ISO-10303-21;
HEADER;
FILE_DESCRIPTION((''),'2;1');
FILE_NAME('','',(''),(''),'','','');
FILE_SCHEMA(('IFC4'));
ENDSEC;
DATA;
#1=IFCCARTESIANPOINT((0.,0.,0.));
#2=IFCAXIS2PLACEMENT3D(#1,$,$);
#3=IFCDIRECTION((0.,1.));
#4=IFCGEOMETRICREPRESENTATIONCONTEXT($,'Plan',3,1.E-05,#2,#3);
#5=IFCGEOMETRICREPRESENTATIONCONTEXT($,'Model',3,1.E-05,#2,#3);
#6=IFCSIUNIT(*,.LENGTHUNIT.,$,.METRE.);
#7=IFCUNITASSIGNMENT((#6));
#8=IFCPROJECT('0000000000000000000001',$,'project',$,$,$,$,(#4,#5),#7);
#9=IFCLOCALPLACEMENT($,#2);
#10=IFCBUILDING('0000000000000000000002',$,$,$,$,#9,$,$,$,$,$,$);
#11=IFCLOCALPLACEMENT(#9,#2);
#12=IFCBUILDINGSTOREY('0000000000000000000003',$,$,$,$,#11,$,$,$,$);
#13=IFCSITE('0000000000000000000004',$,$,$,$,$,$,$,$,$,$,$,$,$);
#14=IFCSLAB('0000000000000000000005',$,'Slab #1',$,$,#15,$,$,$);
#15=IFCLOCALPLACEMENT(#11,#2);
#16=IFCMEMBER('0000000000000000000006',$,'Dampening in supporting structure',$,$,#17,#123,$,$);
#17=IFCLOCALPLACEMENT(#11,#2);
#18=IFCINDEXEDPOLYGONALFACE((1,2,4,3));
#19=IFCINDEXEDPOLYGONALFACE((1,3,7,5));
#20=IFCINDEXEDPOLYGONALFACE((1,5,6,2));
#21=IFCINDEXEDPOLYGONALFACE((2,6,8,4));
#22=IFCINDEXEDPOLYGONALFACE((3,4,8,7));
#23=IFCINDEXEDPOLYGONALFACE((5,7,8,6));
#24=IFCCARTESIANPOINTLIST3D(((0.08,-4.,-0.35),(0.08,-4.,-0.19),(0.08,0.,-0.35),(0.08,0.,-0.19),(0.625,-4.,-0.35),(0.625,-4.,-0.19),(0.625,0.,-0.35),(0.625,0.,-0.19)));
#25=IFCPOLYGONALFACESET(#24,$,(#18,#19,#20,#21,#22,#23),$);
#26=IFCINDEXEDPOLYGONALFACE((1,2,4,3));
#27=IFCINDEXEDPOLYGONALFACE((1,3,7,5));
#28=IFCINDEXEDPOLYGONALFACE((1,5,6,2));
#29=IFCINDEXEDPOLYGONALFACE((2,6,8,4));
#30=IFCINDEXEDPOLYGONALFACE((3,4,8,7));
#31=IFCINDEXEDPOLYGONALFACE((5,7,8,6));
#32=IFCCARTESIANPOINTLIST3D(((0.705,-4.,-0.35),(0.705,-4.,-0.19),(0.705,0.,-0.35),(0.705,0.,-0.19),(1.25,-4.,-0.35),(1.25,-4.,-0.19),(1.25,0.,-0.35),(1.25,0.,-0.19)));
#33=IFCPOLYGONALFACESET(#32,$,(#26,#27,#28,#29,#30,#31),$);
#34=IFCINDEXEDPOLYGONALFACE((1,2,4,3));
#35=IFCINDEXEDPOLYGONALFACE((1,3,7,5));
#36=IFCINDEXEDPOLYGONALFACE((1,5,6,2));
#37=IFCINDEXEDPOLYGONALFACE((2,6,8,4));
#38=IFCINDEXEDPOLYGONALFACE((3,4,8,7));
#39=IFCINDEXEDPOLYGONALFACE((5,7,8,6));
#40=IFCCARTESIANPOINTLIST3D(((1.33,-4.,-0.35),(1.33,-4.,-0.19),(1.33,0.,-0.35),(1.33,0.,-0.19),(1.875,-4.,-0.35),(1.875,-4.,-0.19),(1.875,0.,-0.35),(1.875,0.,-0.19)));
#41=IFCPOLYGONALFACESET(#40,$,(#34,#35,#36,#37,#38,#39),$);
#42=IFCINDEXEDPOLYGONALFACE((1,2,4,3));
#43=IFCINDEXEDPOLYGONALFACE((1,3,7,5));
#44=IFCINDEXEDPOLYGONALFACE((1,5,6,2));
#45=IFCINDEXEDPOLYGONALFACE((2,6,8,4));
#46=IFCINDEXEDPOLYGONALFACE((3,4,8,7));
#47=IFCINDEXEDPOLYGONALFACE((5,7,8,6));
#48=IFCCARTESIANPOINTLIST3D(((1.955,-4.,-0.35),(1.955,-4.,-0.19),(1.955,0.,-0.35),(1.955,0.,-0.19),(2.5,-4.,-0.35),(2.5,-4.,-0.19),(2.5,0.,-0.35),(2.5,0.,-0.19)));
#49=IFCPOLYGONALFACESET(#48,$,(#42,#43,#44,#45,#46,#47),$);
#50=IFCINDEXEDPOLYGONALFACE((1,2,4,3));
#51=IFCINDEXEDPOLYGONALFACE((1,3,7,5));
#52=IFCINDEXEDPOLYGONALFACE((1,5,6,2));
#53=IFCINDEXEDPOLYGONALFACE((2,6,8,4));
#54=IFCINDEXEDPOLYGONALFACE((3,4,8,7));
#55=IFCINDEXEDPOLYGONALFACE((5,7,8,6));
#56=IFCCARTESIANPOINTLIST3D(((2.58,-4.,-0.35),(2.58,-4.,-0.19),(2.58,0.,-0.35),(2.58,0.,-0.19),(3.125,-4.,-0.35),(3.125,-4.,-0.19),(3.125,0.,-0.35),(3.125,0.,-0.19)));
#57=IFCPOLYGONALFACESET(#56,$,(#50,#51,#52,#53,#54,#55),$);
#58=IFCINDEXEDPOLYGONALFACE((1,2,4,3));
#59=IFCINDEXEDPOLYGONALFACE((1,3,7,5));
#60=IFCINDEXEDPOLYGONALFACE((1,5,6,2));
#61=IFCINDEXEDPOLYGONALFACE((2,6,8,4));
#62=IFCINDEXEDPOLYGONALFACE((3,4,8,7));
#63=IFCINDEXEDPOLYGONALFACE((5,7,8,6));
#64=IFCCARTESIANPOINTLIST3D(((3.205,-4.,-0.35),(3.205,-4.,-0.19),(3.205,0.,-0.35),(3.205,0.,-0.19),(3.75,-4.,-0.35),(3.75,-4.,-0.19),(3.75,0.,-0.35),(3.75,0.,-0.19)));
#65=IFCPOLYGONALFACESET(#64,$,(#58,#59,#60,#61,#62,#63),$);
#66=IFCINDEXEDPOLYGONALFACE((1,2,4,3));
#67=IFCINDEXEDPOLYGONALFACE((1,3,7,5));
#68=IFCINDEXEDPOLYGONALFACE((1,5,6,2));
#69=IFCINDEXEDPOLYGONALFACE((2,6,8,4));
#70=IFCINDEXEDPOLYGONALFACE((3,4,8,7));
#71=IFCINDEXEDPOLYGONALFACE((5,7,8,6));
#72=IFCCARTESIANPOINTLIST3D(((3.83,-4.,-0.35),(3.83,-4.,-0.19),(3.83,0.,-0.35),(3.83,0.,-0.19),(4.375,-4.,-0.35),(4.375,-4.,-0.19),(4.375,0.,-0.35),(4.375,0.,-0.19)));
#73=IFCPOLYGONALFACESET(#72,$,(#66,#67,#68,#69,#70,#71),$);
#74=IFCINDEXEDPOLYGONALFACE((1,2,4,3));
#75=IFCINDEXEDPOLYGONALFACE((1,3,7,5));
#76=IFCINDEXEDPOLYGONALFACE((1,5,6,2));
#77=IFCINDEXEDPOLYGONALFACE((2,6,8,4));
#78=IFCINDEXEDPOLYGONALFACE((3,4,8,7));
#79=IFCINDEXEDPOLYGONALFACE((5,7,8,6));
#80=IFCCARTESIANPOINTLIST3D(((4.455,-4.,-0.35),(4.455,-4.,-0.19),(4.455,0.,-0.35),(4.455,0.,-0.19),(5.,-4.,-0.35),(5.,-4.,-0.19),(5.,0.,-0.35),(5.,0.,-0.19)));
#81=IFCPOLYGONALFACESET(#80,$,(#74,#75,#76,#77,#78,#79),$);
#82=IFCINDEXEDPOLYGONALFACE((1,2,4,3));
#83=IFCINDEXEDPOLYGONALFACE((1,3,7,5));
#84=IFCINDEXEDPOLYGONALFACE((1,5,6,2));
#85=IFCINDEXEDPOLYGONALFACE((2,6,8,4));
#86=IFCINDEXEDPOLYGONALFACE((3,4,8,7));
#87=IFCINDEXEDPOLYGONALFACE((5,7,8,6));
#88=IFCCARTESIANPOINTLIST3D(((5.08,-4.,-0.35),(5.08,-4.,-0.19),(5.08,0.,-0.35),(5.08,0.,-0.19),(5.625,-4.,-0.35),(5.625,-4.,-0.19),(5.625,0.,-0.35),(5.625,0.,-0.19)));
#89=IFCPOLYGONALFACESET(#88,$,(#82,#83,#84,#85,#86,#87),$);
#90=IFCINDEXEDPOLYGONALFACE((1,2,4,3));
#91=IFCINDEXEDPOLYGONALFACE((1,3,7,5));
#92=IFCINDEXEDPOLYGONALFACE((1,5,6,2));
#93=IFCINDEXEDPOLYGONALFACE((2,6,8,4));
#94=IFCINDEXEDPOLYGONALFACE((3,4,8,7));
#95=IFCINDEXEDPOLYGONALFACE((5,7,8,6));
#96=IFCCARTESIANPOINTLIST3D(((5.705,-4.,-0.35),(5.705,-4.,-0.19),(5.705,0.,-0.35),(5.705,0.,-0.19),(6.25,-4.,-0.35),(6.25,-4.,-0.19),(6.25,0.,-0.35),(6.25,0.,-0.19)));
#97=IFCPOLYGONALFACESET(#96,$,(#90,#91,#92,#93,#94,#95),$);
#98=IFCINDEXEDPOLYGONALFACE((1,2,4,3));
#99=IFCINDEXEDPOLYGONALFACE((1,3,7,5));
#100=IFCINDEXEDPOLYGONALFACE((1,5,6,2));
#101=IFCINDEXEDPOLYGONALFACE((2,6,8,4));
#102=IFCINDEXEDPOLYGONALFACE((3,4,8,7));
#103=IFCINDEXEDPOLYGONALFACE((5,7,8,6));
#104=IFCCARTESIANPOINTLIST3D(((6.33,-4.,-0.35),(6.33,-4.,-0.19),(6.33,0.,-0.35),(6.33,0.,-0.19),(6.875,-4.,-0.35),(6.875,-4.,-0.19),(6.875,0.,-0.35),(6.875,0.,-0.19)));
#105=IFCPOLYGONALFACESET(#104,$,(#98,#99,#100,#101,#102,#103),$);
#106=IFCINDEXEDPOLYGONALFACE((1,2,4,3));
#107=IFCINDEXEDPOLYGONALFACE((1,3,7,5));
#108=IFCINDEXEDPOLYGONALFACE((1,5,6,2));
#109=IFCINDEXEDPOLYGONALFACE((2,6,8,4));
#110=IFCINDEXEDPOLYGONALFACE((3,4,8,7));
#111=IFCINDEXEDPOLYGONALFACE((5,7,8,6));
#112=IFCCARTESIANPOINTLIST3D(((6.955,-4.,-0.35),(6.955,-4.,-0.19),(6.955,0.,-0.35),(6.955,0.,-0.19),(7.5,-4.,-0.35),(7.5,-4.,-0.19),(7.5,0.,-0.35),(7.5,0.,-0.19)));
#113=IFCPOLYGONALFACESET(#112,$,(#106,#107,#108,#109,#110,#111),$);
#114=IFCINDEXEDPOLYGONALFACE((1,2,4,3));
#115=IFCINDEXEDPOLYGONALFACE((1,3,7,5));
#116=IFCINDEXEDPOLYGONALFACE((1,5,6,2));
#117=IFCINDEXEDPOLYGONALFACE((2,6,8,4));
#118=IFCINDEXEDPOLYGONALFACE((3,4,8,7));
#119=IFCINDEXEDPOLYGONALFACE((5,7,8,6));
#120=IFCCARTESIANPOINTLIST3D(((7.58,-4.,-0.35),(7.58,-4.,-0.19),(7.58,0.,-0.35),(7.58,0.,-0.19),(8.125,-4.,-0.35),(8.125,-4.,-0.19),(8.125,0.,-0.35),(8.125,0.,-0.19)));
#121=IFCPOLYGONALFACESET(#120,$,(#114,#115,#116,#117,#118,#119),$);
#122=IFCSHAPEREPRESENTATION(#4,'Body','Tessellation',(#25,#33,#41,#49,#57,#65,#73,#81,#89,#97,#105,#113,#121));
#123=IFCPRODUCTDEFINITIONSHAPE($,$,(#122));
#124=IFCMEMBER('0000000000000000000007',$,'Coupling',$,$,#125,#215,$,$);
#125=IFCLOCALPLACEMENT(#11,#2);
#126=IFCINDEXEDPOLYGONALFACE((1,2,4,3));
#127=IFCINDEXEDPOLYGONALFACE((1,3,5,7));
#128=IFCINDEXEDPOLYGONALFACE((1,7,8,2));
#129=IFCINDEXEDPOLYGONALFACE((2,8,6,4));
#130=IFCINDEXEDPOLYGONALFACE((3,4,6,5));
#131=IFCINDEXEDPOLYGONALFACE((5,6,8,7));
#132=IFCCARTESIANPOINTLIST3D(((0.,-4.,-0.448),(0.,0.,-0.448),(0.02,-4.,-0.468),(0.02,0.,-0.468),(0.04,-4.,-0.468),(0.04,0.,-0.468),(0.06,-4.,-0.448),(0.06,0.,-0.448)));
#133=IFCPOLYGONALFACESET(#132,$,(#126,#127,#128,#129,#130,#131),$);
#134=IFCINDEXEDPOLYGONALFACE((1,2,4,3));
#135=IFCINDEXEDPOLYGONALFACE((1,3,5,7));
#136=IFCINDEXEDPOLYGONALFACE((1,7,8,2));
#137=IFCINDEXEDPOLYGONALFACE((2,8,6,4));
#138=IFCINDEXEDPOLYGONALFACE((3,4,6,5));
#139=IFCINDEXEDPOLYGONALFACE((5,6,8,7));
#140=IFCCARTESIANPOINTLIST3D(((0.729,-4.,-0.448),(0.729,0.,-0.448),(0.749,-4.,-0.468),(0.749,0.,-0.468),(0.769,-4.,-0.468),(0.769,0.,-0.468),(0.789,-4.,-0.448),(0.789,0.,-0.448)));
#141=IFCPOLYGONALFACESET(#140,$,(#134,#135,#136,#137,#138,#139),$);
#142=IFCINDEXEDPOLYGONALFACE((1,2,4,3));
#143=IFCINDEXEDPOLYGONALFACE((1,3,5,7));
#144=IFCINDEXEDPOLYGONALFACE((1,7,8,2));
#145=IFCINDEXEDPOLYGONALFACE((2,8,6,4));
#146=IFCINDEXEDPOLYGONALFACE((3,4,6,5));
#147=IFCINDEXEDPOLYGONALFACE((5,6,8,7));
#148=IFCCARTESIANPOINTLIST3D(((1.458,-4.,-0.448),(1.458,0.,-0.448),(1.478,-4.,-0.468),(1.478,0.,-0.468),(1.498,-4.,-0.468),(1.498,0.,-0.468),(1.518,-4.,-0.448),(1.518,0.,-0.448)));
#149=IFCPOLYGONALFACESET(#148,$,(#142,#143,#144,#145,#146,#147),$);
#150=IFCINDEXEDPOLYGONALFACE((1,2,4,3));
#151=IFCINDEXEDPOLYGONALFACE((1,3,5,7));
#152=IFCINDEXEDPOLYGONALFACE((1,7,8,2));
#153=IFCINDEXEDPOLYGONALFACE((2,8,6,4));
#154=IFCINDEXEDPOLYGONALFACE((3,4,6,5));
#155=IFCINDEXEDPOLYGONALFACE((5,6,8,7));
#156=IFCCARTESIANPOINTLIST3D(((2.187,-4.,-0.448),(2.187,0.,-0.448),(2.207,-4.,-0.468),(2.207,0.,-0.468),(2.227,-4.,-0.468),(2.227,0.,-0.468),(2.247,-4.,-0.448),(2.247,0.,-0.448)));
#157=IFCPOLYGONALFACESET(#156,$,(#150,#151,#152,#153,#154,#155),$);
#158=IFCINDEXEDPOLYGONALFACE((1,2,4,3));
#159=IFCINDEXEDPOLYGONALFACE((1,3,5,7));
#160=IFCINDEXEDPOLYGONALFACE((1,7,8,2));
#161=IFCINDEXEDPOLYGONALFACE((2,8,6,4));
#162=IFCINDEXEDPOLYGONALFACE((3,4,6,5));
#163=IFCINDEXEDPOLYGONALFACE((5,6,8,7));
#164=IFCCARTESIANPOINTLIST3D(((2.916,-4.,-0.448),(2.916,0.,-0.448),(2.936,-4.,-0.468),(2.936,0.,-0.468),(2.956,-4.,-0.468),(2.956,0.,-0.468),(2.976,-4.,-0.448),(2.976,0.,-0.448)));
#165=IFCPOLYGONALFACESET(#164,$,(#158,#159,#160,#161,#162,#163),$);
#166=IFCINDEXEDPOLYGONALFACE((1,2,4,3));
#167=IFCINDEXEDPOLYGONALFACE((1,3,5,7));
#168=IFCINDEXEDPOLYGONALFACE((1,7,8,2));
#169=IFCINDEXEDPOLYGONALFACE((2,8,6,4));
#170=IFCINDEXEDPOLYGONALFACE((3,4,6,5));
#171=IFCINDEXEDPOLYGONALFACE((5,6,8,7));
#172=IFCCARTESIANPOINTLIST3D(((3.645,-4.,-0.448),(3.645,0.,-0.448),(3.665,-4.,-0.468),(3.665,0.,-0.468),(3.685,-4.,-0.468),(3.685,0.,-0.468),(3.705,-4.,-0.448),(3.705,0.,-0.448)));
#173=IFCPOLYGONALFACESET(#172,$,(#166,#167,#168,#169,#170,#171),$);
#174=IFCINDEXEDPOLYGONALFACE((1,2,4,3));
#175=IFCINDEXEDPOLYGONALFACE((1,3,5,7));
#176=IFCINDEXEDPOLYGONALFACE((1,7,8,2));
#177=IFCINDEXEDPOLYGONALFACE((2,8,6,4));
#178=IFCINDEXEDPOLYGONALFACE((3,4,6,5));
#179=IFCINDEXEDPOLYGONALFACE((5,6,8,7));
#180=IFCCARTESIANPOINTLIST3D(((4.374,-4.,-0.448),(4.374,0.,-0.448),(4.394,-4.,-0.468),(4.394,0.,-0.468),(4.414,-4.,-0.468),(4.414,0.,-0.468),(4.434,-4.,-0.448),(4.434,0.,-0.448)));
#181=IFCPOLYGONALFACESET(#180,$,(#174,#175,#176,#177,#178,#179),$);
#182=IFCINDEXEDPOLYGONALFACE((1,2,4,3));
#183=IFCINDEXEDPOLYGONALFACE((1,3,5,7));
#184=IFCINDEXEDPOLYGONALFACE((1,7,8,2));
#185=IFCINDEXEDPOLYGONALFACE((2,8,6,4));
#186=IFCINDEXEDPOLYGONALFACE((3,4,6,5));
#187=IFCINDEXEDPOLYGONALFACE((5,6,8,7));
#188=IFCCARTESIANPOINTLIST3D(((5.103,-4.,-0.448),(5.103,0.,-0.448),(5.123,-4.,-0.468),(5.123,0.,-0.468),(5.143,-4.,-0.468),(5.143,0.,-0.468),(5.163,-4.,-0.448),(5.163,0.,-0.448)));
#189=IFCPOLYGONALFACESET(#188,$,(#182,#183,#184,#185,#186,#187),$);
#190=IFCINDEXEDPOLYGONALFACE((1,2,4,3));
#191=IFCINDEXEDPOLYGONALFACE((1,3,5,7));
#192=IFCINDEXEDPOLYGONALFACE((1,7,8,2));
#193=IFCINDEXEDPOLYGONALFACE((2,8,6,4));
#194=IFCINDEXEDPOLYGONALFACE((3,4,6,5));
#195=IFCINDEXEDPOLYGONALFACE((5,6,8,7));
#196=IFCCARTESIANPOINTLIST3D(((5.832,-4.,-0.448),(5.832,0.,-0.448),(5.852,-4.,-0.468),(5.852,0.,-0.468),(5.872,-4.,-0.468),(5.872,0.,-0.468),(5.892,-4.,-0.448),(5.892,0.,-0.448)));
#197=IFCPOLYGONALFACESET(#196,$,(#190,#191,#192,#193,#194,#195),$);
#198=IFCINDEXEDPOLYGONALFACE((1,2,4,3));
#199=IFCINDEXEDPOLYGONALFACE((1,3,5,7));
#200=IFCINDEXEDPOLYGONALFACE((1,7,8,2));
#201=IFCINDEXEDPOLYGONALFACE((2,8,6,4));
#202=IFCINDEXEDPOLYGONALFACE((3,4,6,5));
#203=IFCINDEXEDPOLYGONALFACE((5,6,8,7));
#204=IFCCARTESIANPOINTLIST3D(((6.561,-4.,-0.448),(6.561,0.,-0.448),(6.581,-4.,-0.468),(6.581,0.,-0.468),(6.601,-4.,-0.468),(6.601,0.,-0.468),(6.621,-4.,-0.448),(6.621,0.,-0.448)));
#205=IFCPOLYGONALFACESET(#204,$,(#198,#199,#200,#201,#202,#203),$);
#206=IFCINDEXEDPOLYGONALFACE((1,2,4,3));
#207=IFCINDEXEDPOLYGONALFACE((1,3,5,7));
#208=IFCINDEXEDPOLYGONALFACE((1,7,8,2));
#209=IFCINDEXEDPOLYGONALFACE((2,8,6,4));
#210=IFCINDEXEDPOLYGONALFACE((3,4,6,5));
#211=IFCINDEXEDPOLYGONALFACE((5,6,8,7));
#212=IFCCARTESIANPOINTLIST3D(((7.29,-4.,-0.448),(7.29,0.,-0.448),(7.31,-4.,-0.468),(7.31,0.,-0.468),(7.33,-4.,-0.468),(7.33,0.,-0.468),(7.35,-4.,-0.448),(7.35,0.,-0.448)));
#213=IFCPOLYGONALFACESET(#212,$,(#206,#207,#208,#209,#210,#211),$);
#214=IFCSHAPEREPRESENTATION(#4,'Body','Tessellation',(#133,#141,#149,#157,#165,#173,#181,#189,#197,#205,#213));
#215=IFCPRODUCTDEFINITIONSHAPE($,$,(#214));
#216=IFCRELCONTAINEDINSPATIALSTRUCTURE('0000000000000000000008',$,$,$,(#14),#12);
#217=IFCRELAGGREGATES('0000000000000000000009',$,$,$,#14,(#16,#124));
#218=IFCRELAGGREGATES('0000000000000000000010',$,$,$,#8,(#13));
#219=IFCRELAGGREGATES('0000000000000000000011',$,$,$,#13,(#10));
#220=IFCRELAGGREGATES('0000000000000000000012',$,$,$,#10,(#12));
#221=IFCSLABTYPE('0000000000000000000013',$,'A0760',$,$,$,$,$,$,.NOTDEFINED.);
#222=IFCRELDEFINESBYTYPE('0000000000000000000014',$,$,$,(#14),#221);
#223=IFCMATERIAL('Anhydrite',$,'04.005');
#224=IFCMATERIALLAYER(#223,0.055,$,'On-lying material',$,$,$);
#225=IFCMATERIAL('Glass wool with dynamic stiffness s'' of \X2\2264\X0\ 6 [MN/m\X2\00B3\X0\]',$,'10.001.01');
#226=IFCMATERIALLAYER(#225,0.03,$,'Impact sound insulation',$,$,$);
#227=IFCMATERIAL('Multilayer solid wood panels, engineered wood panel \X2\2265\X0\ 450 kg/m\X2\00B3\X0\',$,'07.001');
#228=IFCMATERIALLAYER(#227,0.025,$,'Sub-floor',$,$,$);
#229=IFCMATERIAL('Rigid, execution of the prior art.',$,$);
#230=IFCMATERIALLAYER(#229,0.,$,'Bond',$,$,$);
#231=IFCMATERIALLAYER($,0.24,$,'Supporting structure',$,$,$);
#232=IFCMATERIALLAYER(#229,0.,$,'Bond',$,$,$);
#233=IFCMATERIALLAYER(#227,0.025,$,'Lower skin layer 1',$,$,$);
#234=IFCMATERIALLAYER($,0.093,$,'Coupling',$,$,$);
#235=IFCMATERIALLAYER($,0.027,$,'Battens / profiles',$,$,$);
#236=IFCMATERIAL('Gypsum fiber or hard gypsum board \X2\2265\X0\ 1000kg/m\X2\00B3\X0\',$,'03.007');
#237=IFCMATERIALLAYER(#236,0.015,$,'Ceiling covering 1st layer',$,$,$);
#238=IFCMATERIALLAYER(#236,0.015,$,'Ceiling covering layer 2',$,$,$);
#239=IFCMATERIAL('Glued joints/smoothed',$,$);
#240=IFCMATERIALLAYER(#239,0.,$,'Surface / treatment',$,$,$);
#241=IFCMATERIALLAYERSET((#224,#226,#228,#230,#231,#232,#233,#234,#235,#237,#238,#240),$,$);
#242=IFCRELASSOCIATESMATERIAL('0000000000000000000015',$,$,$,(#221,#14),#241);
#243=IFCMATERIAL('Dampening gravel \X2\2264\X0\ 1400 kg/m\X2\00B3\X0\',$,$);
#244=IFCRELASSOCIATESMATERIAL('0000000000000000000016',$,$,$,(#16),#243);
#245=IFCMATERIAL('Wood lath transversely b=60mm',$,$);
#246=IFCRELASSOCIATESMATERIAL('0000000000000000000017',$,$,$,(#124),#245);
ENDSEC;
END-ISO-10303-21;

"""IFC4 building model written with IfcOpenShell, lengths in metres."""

from ifc_helpers import new_model, si_unit, direction, frame, frame_2d, origin, place, context, project, spatial, polyline, rectangle, outline, extrude, material, layer, layer_set, type_object, element, aggregate, save


model = new_model("IFC4")

# Units and contexts
plan_context = context("Plan", 3, precision=1e-05, world=origin(), true_north=direction((0.0, 1.0)))
model_context = context("Model", 3, precision=1e-05, world=origin(), true_north=direction((0.0, 1.0)))
ifc_project = project(units=[si_unit("LENGTHUNIT", "METRE")], contexts=[plan_context, model_context])

# Site, building, storey
site = spatial("IfcSite", under=ifc_project)
building_placement = place(None, origin())
building = spatial("IfcBuilding", under=site, at=building_placement)
storey_placement = place(building_placement, origin())
storey = spatial("IfcBuildingStorey", under=building, at=storey_placement)

# Slab, members
ifc_material_1 = material(Name="Anhydrite", Category="04.005")
ifc_layer_1 = layer(ifc_material_1, 0.055, Name="On-lying material")
ifc_material_2 = material(Name="Glass wool with dynamic stiffness s' of ≤ 6 [MN/m³]", Category="10.001.01")
ifc_layer_2 = layer(ifc_material_2, 0.03, Name="Impact sound insulation")
ifc_material_3 = material(Name="Multilayer solid wood panels, engineered wood panel ≥ 450 kg/m³", Category="07.001")
ifc_layer_3 = layer(ifc_material_3, 0.025, Name="Sub-floor")
ifc_material_4 = material(Name="Rigid, execution of the prior art.")
ifc_layer_4 = layer(ifc_material_4, 0.0, Name="Bond")
ifc_layer_5 = layer(None, 0.24, Name="Supporting structure")
ifc_layer_6 = layer(ifc_material_4, 0.0, Name="Bond")
ifc_layer_7 = layer(ifc_material_3, 0.025, Name="Lower skin layer 1")
ifc_layer_8 = layer(None, 0.093, Name="Coupling")
ifc_layer_9 = layer(None, 0.027, Name="Battens / profiles")
ifc_material_5 = material(Name="Gypsum fiber or hard gypsum board ≥ 1000kg/m³", Category="03.007")
ifc_layer_10 = layer(ifc_material_5, 0.015, Name="Ceiling covering 1st layer")
ifc_layer_11 = layer(ifc_material_5, 0.015, Name="Ceiling covering layer 2")
ifc_material_6 = material(Name="Glued joints/smoothed")
ifc_layer_12 = layer(ifc_material_6, 0.0, Name="Surface / treatment")
ifc_layer_set = layer_set([ifc_layer_1, ifc_layer_2, ifc_layer_3, ifc_layer_4, ifc_layer_5, ifc_layer_6, ifc_layer_7, ifc_layer_8, ifc_layer_9, ifc_layer_10, ifc_layer_11, ifc_layer_12])
slab_type = type_object("IfcSlabType", Name="A0760", PredefinedType="NOTDEFINED", material=ifc_layer_set)
slab_placement = place(None, frame((0.0, 0.0, 0.0), z_axis=(0.0, 0.0, -1.0), x_axis=(1.0, 0.0, 0.0)))
slab = element("IfcSlab", 1, at=slab_placement, inside=storey, type_object=slab_type, material=ifc_layer_set, Name="Slab #1")
ifc_material_7 = material(Name="Dampening gravel ≤ 1400 kg/m³")
member_1_placement = place(slab_placement, origin())
member_1 = element("IfcMember", 2, at=member_1_placement, material=ifc_material_7, Name="Dampening in supporting structure", context=plan_context, shape_type="SweptSolid", body=[
    extrude(rectangle(XDim=0.545, YDim=0.16, at=frame_2d((0.2725, 0.08), x_axis=(1.0, 0.0))), frame((0.08, 4.0, 0.19), z_axis=(0.0, -1.0, 0.0), x_axis=(1.0, 0.0, 0.0)), (0.0, 0.0, 1.0), 4.0),
    extrude(rectangle(XDim=0.545, YDim=0.16, at=frame_2d((0.2725, 0.08), x_axis=(1.0, 0.0))), frame((0.705, 4.0, 0.19), z_axis=(0.0, -1.0, 0.0), x_axis=(1.0, 0.0, 0.0)), (0.0, 0.0, 1.0), 4.0),
    extrude(rectangle(XDim=0.545, YDim=0.16, at=frame_2d((0.2725, 0.08), x_axis=(1.0, 0.0))), frame((1.33, 4.0, 0.19), z_axis=(0.0, -1.0, 0.0), x_axis=(1.0, 0.0, 0.0)), (0.0, 0.0, 1.0), 4.0),
    extrude(rectangle(XDim=0.545, YDim=0.16, at=frame_2d((0.2725, 0.08), x_axis=(1.0, 0.0))), frame((1.955, 4.0, 0.19), z_axis=(0.0, -1.0, 0.0), x_axis=(1.0, 0.0, 0.0)), (0.0, 0.0, 1.0), 4.0),
    extrude(rectangle(XDim=0.545, YDim=0.16, at=frame_2d((0.2725, 0.08), x_axis=(1.0, 0.0))), frame((2.58, 4.0, 0.19), z_axis=(0.0, -1.0, 0.0), x_axis=(1.0, 0.0, 0.0)), (0.0, 0.0, 1.0), 4.0),
    extrude(rectangle(XDim=0.545, YDim=0.16, at=frame_2d((0.2725, 0.08), x_axis=(1.0, 0.0))), frame((3.205, 4.0, 0.19), z_axis=(0.0, -1.0, 0.0), x_axis=(1.0, 0.0, 0.0)), (0.0, 0.0, 1.0), 4.0),
    extrude(rectangle(XDim=0.545, YDim=0.16, at=frame_2d((0.2725, 0.08), x_axis=(1.0, 0.0))), frame((3.83, 4.0, 0.19), z_axis=(0.0, -1.0, 0.0), x_axis=(1.0, 0.0, 0.0)), (0.0, 0.0, 1.0), 4.0),
    extrude(rectangle(XDim=0.545, YDim=0.16, at=frame_2d((0.2725, 0.08), x_axis=(1.0, 0.0))), frame((4.455, 4.0, 0.19), z_axis=(0.0, -1.0, 0.0), x_axis=(1.0, 0.0, 0.0)), (0.0, 0.0, 1.0), 4.0),
    extrude(rectangle(XDim=0.545, YDim=0.16, at=frame_2d((0.2725, 0.08), x_axis=(1.0, 0.0))), frame((5.08, 4.0, 0.19), z_axis=(0.0, -1.0, 0.0), x_axis=(1.0, 0.0, 0.0)), (0.0, 0.0, 1.0), 4.0),
    extrude(rectangle(XDim=0.545, YDim=0.16, at=frame_2d((0.2725, 0.08), x_axis=(1.0, 0.0))), frame((5.705, 4.0, 0.19), z_axis=(0.0, -1.0, 0.0), x_axis=(1.0, 0.0, 0.0)), (0.0, 0.0, 1.0), 4.0),
    extrude(rectangle(XDim=0.545, YDim=0.16, at=frame_2d((0.2725, 0.08), x_axis=(1.0, 0.0))), frame((6.33, 4.0, 0.19), z_axis=(0.0, -1.0, 0.0), x_axis=(1.0, 0.0, 0.0)), (0.0, 0.0, 1.0), 4.0),
    extrude(rectangle(XDim=0.545, YDim=0.16, at=frame_2d((0.2725, 0.08), x_axis=(1.0, 0.0))), frame((6.955, 4.0, 0.19), z_axis=(0.0, -1.0, 0.0), x_axis=(1.0, 0.0, 0.0)), (0.0, 0.0, 1.0), 4.0),
    extrude(rectangle(XDim=0.545, YDim=0.16, at=frame_2d((0.2725, 0.08), x_axis=(1.0, 0.0))), frame((7.58, 4.0, 0.19), z_axis=(0.0, -1.0, 0.0), x_axis=(1.0, 0.0, 0.0)), (0.0, 0.0, 1.0), 4.0),
])
ifc_material_8 = material(Name="Wood lath transversely b=60mm")
member_2_placement = place(slab_placement, origin())
member_2 = element("IfcMember", 3, at=member_2_placement, material=ifc_material_8, Name="Coupling", context=plan_context, shape_type="SweptSolid", body=[
    extrude(outline(polyline([(0.0, 0.0), (0.06, 0.0), (0.04, 0.02), (0.02, 0.02), (0.0, 0.0)])), frame((0.0, 4.0, 0.448), z_axis=(0.0, -1.0, 0.0), x_axis=(1.0, 0.0, 0.0)), (0.0, 0.0, 1.0), 4.0),
    extrude(outline(polyline([(0.0, 0.0), (0.06, 0.0), (0.04, 0.02), (0.02, 0.02), (0.0, 0.0)])), frame((0.729, 4.0, 0.448), z_axis=(0.0, -1.0, 0.0), x_axis=(1.0, 0.0, 0.0)), (0.0, 0.0, 1.0), 4.0),
    extrude(outline(polyline([(0.0, 0.0), (0.06, 0.0), (0.04, 0.02), (0.02, 0.02), (0.0, 0.0)])), frame((1.458, 4.0, 0.448), z_axis=(0.0, -1.0, 0.0), x_axis=(1.0, 0.0, 0.0)), (0.0, 0.0, 1.0), 4.0),
    extrude(outline(polyline([(0.0, 0.0), (0.06, 0.0), (0.04, 0.02), (0.02, 0.02), (0.0, 0.0)])), frame((2.187, 4.0, 0.448), z_axis=(0.0, -1.0, 0.0), x_axis=(1.0, 0.0, 0.0)), (0.0, 0.0, 1.0), 4.0),
    extrude(outline(polyline([(0.0, 0.0), (0.06, 0.0), (0.04, 0.02), (0.02, 0.02), (0.0, 0.0)])), frame((2.916, 4.0, 0.448), z_axis=(0.0, -1.0, 0.0), x_axis=(1.0, 0.0, 0.0)), (0.0, 0.0, 1.0), 4.0),
    extrude(outline(polyline([(0.0, 0.0), (0.06, 0.0), (0.04, 0.02), (0.02, 0.02), (0.0, 0.0)])), frame((3.645, 4.0, 0.448), z_axis=(0.0, -1.0, 0.0), x_axis=(1.0, 0.0, 0.0)), (0.0, 0.0, 1.0), 4.0),
    extrude(outline(polyline([(0.0, 0.0), (0.06, 0.0), (0.04, 0.02), (0.02, 0.02), (0.0, 0.0)])), frame((4.374, 4.0, 0.448), z_axis=(0.0, -1.0, 0.0), x_axis=(1.0, 0.0, 0.0)), (0.0, 0.0, 1.0), 4.0),
    extrude(outline(polyline([(0.0, 0.0), (0.06, 0.0), (0.04, 0.02), (0.02, 0.02), (0.0, 0.0)])), frame((5.103, 4.0, 0.448), z_axis=(0.0, -1.0, 0.0), x_axis=(1.0, 0.0, 0.0)), (0.0, 0.0, 1.0), 4.0),
    extrude(outline(polyline([(0.0, 0.0), (0.06, 0.0), (0.04, 0.02), (0.02, 0.02), (0.0, 0.0)])), frame((5.832, 4.0, 0.448), z_axis=(0.0, -1.0, 0.0), x_axis=(1.0, 0.0, 0.0)), (0.0, 0.0, 1.0), 4.0),
    extrude(outline(polyline([(0.0, 0.0), (0.06, 0.0), (0.04, 0.02), (0.02, 0.02), (0.0, 0.0)])), frame((6.561, 4.0, 0.448), z_axis=(0.0, -1.0, 0.0), x_axis=(1.0, 0.0, 0.0)), (0.0, 0.0, 1.0), 4.0),
    extrude(outline(polyline([(0.0, 0.0), (0.06, 0.0), (0.04, 0.02), (0.02, 0.02), (0.0, 0.0)])), frame((7.29, 4.0, 0.448), z_axis=(0.0, -1.0, 0.0), x_axis=(1.0, 0.0, 0.0)), (0.0, 0.0, 1.0), 4.0),
])
aggregate(slab, [member_1, member_2])

save(model, "model.ifc")
